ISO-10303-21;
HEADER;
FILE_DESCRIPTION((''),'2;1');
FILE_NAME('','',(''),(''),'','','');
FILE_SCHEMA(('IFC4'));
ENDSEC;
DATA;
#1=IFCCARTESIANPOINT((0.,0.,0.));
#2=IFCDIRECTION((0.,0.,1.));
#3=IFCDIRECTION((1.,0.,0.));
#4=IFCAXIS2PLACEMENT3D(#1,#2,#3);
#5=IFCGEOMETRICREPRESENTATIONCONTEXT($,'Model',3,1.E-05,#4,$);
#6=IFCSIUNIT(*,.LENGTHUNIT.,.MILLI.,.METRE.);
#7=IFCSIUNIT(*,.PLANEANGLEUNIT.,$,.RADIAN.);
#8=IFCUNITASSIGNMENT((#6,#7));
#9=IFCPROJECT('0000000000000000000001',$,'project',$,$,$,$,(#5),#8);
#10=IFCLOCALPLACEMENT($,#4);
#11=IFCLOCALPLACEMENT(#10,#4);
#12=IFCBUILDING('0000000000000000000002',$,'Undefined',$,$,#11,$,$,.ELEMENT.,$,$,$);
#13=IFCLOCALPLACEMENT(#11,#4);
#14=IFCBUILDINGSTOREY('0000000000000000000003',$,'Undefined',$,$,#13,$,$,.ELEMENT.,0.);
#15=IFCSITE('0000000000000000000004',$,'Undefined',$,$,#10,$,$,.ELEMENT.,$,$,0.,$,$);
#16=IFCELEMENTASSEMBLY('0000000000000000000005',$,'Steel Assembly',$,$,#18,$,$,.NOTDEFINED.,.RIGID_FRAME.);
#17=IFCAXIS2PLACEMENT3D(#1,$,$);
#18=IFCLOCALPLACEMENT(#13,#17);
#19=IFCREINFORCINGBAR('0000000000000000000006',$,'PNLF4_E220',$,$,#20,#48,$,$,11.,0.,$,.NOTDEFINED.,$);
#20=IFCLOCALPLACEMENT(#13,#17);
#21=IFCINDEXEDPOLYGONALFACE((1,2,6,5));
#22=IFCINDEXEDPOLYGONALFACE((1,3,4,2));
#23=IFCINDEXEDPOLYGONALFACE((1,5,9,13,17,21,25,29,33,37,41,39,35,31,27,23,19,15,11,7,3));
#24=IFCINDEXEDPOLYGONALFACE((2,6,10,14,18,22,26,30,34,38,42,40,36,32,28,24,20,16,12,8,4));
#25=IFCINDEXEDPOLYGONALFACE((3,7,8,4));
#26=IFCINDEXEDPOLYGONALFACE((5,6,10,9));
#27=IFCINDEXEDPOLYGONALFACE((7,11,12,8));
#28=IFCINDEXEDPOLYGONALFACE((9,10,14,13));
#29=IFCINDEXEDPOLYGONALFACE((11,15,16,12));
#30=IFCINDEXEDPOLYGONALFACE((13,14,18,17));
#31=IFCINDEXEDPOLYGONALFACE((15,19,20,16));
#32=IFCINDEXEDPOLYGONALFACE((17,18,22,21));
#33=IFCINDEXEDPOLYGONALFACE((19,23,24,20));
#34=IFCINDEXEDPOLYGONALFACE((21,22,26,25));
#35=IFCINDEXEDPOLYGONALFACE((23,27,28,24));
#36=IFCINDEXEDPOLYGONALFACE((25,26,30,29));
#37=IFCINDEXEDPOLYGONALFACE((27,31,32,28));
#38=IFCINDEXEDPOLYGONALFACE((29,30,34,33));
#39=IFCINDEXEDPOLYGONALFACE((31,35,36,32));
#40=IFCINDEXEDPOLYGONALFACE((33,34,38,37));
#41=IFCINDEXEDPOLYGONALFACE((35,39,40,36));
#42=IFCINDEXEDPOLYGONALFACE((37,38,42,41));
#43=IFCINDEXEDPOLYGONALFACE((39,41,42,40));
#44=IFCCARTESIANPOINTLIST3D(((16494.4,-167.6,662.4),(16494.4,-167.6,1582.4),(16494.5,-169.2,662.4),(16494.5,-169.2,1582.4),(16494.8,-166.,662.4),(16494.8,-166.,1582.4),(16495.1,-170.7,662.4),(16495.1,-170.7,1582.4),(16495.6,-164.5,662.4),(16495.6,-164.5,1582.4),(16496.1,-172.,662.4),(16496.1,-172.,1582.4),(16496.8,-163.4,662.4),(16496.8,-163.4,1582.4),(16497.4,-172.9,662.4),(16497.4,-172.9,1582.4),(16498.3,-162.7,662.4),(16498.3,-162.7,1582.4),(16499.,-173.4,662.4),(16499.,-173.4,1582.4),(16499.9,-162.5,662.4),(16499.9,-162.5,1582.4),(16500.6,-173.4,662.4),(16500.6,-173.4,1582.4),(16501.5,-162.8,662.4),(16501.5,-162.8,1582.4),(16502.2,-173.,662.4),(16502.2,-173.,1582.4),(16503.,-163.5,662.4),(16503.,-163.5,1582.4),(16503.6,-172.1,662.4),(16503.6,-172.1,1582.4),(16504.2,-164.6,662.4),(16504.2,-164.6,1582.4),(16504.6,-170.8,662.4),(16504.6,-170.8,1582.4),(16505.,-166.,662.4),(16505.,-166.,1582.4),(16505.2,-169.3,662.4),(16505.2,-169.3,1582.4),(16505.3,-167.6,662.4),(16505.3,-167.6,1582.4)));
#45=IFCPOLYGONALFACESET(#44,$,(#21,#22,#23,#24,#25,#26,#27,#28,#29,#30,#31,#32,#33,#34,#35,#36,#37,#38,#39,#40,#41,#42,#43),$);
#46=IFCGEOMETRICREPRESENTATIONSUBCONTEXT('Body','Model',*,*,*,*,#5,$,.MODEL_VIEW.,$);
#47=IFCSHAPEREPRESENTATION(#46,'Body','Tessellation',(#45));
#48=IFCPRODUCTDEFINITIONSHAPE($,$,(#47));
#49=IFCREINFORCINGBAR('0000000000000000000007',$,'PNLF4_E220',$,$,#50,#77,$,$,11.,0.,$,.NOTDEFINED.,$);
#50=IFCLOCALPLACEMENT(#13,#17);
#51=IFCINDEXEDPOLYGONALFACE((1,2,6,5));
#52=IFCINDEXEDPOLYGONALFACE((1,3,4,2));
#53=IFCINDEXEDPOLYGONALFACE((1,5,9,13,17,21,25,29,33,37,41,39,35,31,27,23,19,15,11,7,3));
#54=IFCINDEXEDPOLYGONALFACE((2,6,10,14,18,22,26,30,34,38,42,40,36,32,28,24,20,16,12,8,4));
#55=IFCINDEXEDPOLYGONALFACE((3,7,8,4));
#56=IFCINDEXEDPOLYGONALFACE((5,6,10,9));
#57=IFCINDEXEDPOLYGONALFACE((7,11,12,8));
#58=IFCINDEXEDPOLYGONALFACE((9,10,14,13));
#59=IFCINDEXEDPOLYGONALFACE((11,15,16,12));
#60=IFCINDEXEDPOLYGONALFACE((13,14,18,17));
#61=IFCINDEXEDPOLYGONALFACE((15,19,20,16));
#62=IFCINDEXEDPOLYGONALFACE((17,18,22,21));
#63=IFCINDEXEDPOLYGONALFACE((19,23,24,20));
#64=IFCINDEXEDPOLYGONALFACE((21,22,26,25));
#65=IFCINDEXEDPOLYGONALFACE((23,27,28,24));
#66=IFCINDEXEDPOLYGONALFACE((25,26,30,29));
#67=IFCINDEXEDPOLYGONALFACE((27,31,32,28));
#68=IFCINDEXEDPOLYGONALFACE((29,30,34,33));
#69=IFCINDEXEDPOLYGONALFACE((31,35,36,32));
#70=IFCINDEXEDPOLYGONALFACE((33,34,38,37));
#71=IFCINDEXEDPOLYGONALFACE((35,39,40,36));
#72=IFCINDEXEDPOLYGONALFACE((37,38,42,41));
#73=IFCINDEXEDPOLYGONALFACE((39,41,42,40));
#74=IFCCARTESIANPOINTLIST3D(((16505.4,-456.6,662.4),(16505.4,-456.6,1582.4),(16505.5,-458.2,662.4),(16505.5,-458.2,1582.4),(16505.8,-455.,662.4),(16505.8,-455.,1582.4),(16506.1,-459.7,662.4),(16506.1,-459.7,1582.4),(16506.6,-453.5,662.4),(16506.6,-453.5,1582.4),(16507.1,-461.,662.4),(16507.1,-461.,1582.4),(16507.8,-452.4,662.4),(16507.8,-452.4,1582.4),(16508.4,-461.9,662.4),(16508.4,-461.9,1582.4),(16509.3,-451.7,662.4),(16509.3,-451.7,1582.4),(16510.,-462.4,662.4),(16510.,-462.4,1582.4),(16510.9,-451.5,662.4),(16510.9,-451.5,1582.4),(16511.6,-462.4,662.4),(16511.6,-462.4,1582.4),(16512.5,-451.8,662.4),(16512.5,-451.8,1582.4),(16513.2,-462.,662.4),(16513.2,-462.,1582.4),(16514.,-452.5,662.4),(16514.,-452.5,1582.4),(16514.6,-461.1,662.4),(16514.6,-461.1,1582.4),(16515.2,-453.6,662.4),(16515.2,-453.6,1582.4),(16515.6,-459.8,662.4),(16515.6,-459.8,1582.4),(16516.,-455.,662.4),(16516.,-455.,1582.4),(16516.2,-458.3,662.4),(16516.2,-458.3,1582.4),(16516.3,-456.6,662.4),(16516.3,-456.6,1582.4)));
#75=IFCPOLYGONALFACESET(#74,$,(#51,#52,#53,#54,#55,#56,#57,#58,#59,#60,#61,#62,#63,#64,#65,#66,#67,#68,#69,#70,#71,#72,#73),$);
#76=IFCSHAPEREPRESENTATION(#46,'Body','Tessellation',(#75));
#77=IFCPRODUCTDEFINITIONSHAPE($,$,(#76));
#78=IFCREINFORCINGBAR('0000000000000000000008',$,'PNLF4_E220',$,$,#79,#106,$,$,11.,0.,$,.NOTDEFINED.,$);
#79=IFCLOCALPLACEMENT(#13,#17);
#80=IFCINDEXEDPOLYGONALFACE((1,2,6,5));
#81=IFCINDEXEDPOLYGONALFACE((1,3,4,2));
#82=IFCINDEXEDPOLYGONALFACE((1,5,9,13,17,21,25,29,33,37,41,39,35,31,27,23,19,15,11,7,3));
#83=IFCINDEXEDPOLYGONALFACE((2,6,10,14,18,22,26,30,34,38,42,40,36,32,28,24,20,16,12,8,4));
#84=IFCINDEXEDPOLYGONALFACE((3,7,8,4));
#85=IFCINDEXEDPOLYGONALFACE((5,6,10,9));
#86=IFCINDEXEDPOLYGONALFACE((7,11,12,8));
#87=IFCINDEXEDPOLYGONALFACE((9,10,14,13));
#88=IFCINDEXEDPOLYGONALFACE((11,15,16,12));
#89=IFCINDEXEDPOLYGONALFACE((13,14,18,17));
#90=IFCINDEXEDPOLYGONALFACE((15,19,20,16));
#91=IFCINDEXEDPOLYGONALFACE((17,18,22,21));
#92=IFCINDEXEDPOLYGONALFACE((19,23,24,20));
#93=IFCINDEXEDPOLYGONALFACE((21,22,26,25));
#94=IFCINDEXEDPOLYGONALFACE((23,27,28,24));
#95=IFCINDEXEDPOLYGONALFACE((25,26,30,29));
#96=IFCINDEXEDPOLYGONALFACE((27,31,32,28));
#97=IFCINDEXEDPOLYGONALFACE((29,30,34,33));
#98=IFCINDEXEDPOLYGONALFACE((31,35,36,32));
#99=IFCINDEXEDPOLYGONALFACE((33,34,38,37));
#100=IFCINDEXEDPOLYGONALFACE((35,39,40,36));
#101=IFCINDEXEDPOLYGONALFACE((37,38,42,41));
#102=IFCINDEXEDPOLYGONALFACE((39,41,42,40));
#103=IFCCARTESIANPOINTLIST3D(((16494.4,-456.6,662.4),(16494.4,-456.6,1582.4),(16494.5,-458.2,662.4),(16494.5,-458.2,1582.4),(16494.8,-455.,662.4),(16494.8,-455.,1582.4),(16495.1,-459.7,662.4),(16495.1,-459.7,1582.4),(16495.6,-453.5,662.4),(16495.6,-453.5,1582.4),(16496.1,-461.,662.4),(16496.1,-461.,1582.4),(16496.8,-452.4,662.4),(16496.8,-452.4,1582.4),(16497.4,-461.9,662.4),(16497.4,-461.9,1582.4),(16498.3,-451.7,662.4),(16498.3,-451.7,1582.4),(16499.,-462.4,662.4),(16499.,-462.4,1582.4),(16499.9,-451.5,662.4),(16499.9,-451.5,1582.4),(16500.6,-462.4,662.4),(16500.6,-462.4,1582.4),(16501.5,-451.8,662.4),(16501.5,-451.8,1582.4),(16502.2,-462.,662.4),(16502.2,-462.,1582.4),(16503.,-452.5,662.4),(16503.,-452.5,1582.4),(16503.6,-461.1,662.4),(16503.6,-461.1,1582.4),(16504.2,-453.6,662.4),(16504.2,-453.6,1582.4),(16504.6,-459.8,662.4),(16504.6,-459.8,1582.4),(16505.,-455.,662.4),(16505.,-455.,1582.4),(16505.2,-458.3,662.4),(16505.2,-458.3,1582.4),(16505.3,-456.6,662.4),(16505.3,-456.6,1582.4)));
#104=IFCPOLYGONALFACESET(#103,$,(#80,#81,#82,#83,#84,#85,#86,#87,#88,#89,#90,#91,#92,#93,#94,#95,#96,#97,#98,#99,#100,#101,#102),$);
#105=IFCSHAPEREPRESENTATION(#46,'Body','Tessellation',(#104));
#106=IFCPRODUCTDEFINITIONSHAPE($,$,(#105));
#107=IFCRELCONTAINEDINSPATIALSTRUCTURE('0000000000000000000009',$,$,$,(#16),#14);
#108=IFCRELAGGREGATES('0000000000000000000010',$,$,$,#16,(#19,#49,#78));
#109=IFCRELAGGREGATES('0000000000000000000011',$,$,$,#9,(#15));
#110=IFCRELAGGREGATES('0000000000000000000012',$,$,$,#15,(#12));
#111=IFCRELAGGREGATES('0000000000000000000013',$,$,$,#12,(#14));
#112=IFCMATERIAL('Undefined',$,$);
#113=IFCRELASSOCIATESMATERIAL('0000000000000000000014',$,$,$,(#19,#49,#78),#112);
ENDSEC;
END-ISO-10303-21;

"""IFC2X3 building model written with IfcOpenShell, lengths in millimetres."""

from ifc_helpers import new_model, entity, si_unit, frame, origin_with_axes, place, context, subcontext, project, spatial, source, transform, mapped, material, element, aggregate, save


model = new_model("IFC2X3")

# Units and contexts
model_context = context("Model", 3, precision=1e-05, world=origin_with_axes())
body_context = subcontext(model_context, "Body", "Model", "MODEL_VIEW")
ifc_project = project(units=[si_unit("LENGTHUNIT", "METRE", prefix="MILLI"), si_unit("PLANEANGLEUNIT", "RADIAN")], contexts=[model_context])

# Site, building, storey
site_placement = place(None, origin_with_axes())
site = spatial("IfcSite", under=ifc_project, at=site_placement, Name="Undefined", CompositionType="ELEMENT", RefElevation=0.0)
building_placement = place(site_placement, origin_with_axes())
building = spatial("IfcBuilding", under=site, at=building_placement, Name="Undefined", CompositionType="ELEMENT")
storey_placement = place(building_placement, origin_with_axes())
storey = spatial("IfcBuildingStorey", under=building, at=storey_placement, Name="Undefined", CompositionType="ELEMENT", Elevation=0.0)

# Shared definitions
ifc_material_1 = material(Name="Undefined")

# Element assembly, reinforcing bars
assembly_1_placement = place(storey_placement, origin_with_axes())
assembly_1 = element("IfcElementAssembly", 1, at=assembly_1_placement, inside=storey, Name="Steel Assembly", AssemblyPlace="NOTDEFINED", PredefinedType="RIGID_FRAME")
shared_shape_1 = source(origin_with_axes(), body_context, "Body", "AdvancedSweptSolid", [
    entity("IfcSweptDiskSolid", entity("IfcTrimmedCurve", entity("IfcLine", entity("IfcCartesianPoint", [0.0, 0.0, 0.0]), entity("IfcVector", entity("IfcDirection", [1.0, 0.0, 0.0]), 1.0)), [entity("IfcParameterValue", 0.0)], [entity("IfcParameterValue", 920.0)], True, "PARAMETER"), 5.5, None, 0.0, 920.0),
])
reinforcing_bar_1_placement = place(assembly_1_placement, frame((16499.9, -168.0, 1582.4), z_axis=(0.006957, 0.999976, 0.0), x_axis=(0.0, 0.0, -1.0)))
reinforcing_bar_1 = element("IfcReinforcingBar", 2, at=reinforcing_bar_1_placement, material=ifc_material_1, Name="PNLF4_E220", BarRole="NOTDEFINED", CrossSectionArea=0.0, NominalDiameter=11.0, context=body_context, shape_type="MappedRepresentation", body=[
    mapped(shared_shape_1, transform((0.0, 0.0, 0.0))),
])
shared_shape_2 = source(origin_with_axes(), body_context, "Body", "AdvancedSweptSolid", [
    entity("IfcSweptDiskSolid", entity("IfcTrimmedCurve", entity("IfcLine", entity("IfcCartesianPoint", [0.0, 0.0, 0.0]), entity("IfcVector", entity("IfcDirection", [1.0, 0.0, 0.0]), 1.0)), [entity("IfcParameterValue", 0.0)], [entity("IfcParameterValue", 920.0)], True, "PARAMETER"), 5.5, None, 0.0, 920.0),
])
reinforcing_bar_2_placement = place(assembly_1_placement, frame((16510.9, -457.0, 1582.4), z_axis=(0.006957, 0.999976, 0.0), x_axis=(0.0, 0.0, -1.0)))
reinforcing_bar_2 = element("IfcReinforcingBar", 3, at=reinforcing_bar_2_placement, material=ifc_material_1, Name="PNLF4_E220", BarRole="NOTDEFINED", CrossSectionArea=0.0, NominalDiameter=11.0, context=body_context, shape_type="MappedRepresentation", body=[
    mapped(shared_shape_2, transform((0.0, 0.0, 0.0))),
])
shared_shape_3 = source(origin_with_axes(), body_context, "Body", "AdvancedSweptSolid", [
    entity("IfcSweptDiskSolid", entity("IfcTrimmedCurve", entity("IfcLine", entity("IfcCartesianPoint", [0.0, 0.0, 0.0]), entity("IfcVector", entity("IfcDirection", [1.0, 0.0, 0.0]), 1.0)), [entity("IfcParameterValue", 0.0)], [entity("IfcParameterValue", 920.0)], True, "PARAMETER"), 5.5, None, 0.0, 920.0),
])
reinforcing_bar_3_placement = place(assembly_1_placement, frame((16499.9, -457.0, 1582.4), z_axis=(0.006957, 0.999976, 0.0), x_axis=(0.0, 0.0, -1.0)))
reinforcing_bar_3 = element("IfcReinforcingBar", 4, at=reinforcing_bar_3_placement, material=ifc_material_1, Name="PNLF4_E220", BarRole="NOTDEFINED", CrossSectionArea=0.0, NominalDiameter=11.0, context=body_context, shape_type="MappedRepresentation", body=[
    mapped(shared_shape_3, transform((0.0, 0.0, 0.0))),
])
aggregate(assembly_1, [reinforcing_bar_1, reinforcing_bar_2, reinforcing_bar_3])

save(model, "model.ifc")
